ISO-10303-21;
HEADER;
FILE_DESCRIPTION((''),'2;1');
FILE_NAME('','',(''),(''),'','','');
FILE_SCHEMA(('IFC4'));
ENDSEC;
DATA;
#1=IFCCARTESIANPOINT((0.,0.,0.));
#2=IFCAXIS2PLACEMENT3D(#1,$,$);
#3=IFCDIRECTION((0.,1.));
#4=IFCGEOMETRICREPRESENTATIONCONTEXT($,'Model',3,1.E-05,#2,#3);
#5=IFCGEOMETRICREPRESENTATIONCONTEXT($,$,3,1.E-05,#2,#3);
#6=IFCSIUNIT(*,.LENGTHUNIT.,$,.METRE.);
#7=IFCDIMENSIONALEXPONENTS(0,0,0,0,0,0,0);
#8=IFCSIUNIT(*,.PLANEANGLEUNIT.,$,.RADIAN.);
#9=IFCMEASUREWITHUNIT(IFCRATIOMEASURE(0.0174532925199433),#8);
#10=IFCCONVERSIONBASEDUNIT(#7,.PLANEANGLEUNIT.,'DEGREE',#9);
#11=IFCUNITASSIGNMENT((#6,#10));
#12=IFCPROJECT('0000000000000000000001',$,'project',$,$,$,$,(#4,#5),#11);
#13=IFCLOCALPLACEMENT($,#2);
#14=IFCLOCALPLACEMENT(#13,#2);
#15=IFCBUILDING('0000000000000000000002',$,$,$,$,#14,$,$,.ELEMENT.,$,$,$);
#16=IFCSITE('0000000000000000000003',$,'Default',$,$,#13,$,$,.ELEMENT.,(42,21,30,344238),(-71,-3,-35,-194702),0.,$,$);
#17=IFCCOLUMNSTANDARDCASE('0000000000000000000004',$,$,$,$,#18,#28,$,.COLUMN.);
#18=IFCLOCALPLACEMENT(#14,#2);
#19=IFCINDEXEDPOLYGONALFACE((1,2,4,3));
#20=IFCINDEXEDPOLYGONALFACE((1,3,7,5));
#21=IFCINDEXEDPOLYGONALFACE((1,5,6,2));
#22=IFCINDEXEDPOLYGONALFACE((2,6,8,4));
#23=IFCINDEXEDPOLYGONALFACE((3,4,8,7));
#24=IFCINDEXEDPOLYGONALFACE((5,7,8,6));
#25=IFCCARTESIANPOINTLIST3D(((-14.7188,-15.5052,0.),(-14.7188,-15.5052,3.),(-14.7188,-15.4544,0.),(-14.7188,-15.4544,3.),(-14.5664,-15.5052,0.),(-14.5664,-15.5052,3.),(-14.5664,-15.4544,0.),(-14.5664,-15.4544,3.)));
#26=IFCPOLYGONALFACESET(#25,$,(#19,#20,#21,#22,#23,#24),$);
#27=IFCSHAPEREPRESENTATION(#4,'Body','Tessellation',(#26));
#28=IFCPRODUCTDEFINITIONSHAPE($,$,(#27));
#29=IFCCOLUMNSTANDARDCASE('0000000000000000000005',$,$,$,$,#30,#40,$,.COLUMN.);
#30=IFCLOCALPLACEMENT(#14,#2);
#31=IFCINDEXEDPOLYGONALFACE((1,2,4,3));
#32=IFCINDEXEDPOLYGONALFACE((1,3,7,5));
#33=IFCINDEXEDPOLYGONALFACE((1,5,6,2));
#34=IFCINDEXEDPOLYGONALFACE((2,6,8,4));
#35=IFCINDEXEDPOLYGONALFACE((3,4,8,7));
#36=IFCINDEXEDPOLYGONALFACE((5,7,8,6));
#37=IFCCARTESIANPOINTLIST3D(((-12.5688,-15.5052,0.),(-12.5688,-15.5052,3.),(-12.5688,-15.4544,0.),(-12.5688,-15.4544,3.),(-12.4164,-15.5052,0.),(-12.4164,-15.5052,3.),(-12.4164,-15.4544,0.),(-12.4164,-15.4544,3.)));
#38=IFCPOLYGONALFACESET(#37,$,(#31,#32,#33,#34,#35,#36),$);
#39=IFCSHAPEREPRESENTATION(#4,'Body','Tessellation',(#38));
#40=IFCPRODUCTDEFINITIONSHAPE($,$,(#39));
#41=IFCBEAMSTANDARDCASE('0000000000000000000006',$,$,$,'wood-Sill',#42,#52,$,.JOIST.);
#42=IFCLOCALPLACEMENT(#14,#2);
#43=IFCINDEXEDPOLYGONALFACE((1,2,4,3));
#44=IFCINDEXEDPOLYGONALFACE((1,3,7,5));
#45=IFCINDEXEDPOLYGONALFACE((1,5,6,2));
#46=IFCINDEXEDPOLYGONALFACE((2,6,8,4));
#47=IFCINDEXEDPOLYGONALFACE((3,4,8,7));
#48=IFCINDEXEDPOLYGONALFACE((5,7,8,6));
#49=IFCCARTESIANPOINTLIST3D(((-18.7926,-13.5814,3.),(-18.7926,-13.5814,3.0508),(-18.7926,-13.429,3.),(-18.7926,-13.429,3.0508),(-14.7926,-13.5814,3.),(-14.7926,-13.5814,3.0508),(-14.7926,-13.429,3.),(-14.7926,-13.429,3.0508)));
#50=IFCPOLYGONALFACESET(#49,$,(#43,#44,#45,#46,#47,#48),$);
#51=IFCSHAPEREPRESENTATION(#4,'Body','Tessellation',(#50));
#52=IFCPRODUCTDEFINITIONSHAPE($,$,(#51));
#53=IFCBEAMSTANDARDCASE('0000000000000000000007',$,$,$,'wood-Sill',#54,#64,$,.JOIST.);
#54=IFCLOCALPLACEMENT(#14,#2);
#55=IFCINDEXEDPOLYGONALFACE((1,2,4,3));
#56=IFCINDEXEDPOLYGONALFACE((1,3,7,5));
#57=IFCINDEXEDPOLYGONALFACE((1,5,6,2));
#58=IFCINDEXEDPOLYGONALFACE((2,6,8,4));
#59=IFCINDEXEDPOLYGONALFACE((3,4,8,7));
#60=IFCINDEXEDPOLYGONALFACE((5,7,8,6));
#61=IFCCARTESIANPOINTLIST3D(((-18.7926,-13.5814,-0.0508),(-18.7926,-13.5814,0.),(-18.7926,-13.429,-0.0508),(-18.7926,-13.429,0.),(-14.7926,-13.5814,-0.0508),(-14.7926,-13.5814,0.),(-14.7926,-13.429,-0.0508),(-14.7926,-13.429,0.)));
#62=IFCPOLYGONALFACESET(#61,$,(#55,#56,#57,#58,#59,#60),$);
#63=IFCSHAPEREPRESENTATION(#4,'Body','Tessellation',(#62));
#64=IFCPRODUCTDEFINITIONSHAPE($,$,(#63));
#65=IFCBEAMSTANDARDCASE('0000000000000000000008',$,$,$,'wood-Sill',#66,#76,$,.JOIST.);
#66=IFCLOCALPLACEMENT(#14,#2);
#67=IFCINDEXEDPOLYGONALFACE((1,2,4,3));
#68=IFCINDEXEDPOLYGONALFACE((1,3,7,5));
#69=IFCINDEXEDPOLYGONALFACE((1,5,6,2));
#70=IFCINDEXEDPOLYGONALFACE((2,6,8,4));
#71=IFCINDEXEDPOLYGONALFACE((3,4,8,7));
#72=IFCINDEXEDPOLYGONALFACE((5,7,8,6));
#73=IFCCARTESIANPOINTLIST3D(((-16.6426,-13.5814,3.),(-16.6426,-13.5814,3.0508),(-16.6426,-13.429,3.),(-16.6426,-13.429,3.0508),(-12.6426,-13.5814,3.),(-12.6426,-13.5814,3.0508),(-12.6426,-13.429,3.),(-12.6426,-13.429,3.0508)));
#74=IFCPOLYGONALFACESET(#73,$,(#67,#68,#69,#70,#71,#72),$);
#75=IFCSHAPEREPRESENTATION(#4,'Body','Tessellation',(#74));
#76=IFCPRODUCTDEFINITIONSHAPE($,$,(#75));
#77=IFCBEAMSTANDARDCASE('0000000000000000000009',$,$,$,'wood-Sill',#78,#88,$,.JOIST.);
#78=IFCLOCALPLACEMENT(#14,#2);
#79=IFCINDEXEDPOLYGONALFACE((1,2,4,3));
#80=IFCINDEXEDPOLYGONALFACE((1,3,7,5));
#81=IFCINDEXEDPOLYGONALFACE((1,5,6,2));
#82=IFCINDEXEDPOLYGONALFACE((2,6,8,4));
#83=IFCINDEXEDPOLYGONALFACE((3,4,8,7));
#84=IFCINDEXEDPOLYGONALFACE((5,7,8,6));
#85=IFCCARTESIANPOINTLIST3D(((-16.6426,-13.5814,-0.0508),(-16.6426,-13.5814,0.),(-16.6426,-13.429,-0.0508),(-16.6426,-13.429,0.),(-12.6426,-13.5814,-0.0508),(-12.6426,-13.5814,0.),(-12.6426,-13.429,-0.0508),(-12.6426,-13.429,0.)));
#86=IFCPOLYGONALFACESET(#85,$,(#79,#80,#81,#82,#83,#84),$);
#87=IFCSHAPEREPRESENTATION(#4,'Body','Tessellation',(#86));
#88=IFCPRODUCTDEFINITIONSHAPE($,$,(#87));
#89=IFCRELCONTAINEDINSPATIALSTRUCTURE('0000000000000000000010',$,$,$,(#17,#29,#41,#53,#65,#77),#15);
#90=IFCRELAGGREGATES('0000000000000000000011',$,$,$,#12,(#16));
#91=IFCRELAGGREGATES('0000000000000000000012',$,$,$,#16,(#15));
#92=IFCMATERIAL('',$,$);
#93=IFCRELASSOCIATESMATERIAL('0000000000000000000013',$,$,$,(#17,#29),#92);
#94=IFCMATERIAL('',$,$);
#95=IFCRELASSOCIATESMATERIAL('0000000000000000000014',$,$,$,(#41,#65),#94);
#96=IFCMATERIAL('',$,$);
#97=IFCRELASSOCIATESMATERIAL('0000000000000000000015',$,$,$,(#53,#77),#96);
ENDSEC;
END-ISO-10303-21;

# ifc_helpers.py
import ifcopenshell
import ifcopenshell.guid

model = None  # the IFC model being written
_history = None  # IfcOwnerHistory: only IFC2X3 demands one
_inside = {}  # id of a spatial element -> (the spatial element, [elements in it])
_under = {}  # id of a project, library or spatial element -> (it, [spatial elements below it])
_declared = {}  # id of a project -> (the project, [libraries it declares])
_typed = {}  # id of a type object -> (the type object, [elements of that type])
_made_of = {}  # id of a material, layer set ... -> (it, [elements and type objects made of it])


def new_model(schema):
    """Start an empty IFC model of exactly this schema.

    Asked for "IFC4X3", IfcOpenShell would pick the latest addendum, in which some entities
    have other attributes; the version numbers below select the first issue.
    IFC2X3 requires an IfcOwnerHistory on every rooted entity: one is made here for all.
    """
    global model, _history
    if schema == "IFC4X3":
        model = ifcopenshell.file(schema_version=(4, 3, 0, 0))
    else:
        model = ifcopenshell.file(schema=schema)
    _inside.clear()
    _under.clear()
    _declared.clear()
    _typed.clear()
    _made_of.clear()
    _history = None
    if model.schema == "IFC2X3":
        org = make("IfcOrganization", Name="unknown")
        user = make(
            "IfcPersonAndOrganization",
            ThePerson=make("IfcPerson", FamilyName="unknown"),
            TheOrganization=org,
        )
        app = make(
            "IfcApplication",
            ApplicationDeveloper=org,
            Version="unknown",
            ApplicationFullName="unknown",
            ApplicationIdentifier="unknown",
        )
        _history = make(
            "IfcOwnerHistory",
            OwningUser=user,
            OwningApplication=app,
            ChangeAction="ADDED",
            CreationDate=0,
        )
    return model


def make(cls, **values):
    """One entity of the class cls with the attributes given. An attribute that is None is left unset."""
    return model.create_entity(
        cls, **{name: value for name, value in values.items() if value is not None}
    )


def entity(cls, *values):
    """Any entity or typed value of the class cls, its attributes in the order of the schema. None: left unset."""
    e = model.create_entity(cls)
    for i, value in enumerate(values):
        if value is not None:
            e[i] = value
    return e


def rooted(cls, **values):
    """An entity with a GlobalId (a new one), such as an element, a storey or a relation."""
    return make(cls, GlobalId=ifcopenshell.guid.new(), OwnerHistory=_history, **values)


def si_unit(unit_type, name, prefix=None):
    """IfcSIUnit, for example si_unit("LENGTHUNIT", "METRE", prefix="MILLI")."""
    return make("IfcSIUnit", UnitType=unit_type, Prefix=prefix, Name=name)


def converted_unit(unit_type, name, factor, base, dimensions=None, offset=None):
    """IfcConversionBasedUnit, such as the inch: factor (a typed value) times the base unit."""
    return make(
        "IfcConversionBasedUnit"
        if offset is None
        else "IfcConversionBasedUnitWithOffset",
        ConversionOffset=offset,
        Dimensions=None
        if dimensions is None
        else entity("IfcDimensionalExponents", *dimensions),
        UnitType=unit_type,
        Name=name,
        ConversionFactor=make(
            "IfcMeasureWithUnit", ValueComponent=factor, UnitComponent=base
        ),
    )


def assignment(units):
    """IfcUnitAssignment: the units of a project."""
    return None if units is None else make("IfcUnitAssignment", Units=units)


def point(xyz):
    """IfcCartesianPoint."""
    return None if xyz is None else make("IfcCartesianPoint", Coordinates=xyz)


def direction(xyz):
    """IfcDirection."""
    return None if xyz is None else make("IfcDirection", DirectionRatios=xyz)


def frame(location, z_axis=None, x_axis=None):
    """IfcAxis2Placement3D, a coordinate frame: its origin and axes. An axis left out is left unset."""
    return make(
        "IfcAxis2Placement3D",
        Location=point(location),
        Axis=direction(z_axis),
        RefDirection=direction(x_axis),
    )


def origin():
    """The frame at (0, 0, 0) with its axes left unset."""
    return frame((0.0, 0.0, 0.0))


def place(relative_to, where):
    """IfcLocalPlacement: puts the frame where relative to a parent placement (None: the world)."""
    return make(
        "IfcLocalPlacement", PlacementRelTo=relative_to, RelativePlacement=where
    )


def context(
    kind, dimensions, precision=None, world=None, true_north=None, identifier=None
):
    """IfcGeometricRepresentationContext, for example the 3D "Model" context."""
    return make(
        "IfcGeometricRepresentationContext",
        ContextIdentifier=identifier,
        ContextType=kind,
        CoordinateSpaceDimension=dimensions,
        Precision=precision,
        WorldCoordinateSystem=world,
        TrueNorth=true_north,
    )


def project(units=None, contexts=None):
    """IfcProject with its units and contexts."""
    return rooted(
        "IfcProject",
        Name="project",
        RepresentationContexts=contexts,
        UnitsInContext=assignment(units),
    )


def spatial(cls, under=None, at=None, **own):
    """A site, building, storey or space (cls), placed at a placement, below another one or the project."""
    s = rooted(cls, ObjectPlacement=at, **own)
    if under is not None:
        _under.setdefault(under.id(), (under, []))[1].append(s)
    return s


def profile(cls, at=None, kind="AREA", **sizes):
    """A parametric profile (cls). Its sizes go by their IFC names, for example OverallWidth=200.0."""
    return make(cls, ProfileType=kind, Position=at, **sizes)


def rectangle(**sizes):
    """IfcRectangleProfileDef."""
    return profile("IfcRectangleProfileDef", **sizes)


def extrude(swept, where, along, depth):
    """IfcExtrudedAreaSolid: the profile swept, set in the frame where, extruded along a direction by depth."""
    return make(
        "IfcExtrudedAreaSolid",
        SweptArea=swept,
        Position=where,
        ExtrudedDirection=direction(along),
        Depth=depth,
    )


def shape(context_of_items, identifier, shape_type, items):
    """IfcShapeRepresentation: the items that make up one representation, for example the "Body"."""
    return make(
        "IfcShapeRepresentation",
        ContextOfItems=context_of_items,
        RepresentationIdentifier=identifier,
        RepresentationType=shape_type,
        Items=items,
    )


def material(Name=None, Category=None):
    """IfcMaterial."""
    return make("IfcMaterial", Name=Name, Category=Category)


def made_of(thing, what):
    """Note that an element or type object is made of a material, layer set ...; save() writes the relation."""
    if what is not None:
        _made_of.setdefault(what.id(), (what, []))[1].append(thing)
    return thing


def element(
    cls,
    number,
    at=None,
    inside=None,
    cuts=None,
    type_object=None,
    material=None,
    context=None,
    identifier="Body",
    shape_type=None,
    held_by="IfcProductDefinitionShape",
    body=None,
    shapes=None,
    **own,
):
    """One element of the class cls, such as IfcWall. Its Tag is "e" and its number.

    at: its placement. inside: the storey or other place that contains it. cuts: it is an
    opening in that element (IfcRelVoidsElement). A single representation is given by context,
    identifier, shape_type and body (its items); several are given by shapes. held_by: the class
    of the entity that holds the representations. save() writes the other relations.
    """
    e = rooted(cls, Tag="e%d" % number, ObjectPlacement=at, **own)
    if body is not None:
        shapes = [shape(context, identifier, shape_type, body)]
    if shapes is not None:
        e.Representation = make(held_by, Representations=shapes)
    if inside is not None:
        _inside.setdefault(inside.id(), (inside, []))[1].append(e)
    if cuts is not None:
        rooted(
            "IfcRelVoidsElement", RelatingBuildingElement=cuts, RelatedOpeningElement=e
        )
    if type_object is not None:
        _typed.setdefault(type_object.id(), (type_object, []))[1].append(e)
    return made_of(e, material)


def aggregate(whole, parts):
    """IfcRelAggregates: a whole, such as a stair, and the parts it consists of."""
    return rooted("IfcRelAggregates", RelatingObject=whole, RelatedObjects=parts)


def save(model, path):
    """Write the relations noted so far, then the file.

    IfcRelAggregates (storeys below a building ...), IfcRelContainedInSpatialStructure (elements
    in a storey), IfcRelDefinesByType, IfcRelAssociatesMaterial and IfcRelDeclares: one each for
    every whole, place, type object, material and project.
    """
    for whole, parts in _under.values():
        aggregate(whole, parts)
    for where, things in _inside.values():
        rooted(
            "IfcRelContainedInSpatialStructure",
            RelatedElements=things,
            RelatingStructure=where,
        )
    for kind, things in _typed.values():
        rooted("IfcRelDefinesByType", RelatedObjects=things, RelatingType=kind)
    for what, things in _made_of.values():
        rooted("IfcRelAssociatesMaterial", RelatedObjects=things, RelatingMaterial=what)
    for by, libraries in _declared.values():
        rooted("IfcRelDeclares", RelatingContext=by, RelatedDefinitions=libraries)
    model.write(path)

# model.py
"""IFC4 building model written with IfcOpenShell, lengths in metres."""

from ifc_helpers import new_model, entity, si_unit, converted_unit, direction, frame, origin, place, context, project, spatial, rectangle, extrude, material, element, save


model = new_model("IFC4")

# Units and contexts
model_context = context("Model", 3, precision=1e-05, world=origin(), true_north=direction((0.0, 1.0)))
context_of_model = context(None, 3, precision=1e-05, world=origin(), true_north=direction((0.0, 1.0)))
ifc_project = project(units=[si_unit("LENGTHUNIT", "METRE"), converted_unit("PLANEANGLEUNIT", "DEGREE", entity("IfcRatioMeasure", 0.0174532925199433), si_unit("PLANEANGLEUNIT", "RADIAN"), dimensions=[0, 0, 0, 0, 0, 0, 0])], contexts=[model_context, context_of_model])

# Site, building
site_placement = place(None, origin())
site = spatial("IfcSite", under=ifc_project, at=site_placement, Name="Default", CompositionType="ELEMENT", RefLatitude=(42, 21, 30, 344238), RefLongitude=(-71, -3, -35, -194702), RefElevation=0.0)
building_placement = place(site_placement, origin())
building = spatial("IfcBuilding", under=site, at=building_placement, CompositionType="ELEMENT")

# Columns
ifc_material_1 = material(Name="")
placement_1 = place(building_placement, origin())
placement_2 = place(placement_1, frame((-14.6426, -15.5052, 0.0), z_axis=(0.0, 0.0, 1.0), x_axis=(0.0, 1.0, 0.0)))
for number, where, z_axis, x_axis in (
    (1, (0.0254, 0.0, 0.0), (0.0, 0.0, 1.0), (1.0, 0.0, 0.0)),
):
    element("IfcColumnStandardCase", number, at=place(placement_2, frame(where, z_axis=z_axis, x_axis=x_axis)), inside=building, material=ifc_material_1, PredefinedType="COLUMN", context=model_context, shape_type="SweptSolid", body=[
        extrude(rectangle(XDim=0.0508, YDim=0.1524), origin(), (0.0, 0.0, 1.0), 3.0),
    ])
placement_3 = place(placement_1, frame((-12.4926, -15.5052, 0.0), z_axis=(0.0, 0.0, 1.0), x_axis=(0.0, 1.0, 0.0)))
for number, where, z_axis, x_axis in (
    (2, (0.0254, 0.0, 0.0), (0.0, 0.0, 1.0), (1.0, 0.0, 0.0)),
):
    element("IfcColumnStandardCase", number, at=place(placement_3, frame(where, z_axis=z_axis, x_axis=x_axis)), inside=building, material=ifc_material_1, PredefinedType="COLUMN", context=model_context, shape_type="SweptSolid", body=[
        extrude(rectangle(XDim=0.0508, YDim=0.1524), origin(), (0.0, 0.0, 1.0), 3.0),
    ])

# Beams
ifc_material_2 = material(Name="")
placement_4 = place(placement_1, frame((-16.7926, -15.5052, 0.0), z_axis=(0.0, 0.0, 1.0), x_axis=(0.0, 1.0, 0.0)))
beam_1_placement = place(placement_4, frame((2.0, 0.0, 3.0), z_axis=(0.0, 0.0, 1.0), x_axis=(0.0, 1.0, 0.0)))
element("IfcBeamStandardCase", 3, at=beam_1_placement, inside=building, material=ifc_material_2, ObjectType="wood-Sill", PredefinedType="JOIST", context=model_context, shape_type="SweptSolid", body=[
    extrude(rectangle(XDim=4.0, YDim=0.1524), origin(), (0.0, 0.0, 1.0), 0.0508),
])
ifc_material_3 = material(Name="")
beam_2_placement = place(placement_4, frame((2.0, 0.0, -0.0508), z_axis=(0.0, 0.0, 1.0), x_axis=(0.0, 1.0, 0.0)))
element("IfcBeamStandardCase", 4, at=beam_2_placement, inside=building, material=ifc_material_3, ObjectType="wood-Sill", PredefinedType="JOIST", context=model_context, shape_type="SweptSolid", body=[
    extrude(rectangle(XDim=4.0, YDim=0.1524), origin(), (0.0, 0.0, 1.0), 0.0508),
])
beam_3_placement = place(placement_2, frame((2.0, 0.0, 3.0), z_axis=(0.0, 0.0, 1.0), x_axis=(0.0, 1.0, 0.0)))
element("IfcBeamStandardCase", 5, at=beam_3_placement, inside=building, material=ifc_material_2, ObjectType="wood-Sill", PredefinedType="JOIST", context=model_context, shape_type="SweptSolid", body=[
    extrude(rectangle(XDim=4.0, YDim=0.1524), origin(), (0.0, 0.0, 1.0), 0.0508),
])
beam_4_placement = place(placement_2, frame((2.0, 0.0, -0.0508), z_axis=(0.0, 0.0, 1.0), x_axis=(0.0, 1.0, 0.0)))
element("IfcBeamStandardCase", 6, at=beam_4_placement, inside=building, material=ifc_material_3, ObjectType="wood-Sill", PredefinedType="JOIST", context=model_context, shape_type="SweptSolid", body=[
    extrude(rectangle(XDim=4.0, YDim=0.1524), origin(), (0.0, 0.0, 1.0), 0.0508),
])

save(model, "model.ifc")
